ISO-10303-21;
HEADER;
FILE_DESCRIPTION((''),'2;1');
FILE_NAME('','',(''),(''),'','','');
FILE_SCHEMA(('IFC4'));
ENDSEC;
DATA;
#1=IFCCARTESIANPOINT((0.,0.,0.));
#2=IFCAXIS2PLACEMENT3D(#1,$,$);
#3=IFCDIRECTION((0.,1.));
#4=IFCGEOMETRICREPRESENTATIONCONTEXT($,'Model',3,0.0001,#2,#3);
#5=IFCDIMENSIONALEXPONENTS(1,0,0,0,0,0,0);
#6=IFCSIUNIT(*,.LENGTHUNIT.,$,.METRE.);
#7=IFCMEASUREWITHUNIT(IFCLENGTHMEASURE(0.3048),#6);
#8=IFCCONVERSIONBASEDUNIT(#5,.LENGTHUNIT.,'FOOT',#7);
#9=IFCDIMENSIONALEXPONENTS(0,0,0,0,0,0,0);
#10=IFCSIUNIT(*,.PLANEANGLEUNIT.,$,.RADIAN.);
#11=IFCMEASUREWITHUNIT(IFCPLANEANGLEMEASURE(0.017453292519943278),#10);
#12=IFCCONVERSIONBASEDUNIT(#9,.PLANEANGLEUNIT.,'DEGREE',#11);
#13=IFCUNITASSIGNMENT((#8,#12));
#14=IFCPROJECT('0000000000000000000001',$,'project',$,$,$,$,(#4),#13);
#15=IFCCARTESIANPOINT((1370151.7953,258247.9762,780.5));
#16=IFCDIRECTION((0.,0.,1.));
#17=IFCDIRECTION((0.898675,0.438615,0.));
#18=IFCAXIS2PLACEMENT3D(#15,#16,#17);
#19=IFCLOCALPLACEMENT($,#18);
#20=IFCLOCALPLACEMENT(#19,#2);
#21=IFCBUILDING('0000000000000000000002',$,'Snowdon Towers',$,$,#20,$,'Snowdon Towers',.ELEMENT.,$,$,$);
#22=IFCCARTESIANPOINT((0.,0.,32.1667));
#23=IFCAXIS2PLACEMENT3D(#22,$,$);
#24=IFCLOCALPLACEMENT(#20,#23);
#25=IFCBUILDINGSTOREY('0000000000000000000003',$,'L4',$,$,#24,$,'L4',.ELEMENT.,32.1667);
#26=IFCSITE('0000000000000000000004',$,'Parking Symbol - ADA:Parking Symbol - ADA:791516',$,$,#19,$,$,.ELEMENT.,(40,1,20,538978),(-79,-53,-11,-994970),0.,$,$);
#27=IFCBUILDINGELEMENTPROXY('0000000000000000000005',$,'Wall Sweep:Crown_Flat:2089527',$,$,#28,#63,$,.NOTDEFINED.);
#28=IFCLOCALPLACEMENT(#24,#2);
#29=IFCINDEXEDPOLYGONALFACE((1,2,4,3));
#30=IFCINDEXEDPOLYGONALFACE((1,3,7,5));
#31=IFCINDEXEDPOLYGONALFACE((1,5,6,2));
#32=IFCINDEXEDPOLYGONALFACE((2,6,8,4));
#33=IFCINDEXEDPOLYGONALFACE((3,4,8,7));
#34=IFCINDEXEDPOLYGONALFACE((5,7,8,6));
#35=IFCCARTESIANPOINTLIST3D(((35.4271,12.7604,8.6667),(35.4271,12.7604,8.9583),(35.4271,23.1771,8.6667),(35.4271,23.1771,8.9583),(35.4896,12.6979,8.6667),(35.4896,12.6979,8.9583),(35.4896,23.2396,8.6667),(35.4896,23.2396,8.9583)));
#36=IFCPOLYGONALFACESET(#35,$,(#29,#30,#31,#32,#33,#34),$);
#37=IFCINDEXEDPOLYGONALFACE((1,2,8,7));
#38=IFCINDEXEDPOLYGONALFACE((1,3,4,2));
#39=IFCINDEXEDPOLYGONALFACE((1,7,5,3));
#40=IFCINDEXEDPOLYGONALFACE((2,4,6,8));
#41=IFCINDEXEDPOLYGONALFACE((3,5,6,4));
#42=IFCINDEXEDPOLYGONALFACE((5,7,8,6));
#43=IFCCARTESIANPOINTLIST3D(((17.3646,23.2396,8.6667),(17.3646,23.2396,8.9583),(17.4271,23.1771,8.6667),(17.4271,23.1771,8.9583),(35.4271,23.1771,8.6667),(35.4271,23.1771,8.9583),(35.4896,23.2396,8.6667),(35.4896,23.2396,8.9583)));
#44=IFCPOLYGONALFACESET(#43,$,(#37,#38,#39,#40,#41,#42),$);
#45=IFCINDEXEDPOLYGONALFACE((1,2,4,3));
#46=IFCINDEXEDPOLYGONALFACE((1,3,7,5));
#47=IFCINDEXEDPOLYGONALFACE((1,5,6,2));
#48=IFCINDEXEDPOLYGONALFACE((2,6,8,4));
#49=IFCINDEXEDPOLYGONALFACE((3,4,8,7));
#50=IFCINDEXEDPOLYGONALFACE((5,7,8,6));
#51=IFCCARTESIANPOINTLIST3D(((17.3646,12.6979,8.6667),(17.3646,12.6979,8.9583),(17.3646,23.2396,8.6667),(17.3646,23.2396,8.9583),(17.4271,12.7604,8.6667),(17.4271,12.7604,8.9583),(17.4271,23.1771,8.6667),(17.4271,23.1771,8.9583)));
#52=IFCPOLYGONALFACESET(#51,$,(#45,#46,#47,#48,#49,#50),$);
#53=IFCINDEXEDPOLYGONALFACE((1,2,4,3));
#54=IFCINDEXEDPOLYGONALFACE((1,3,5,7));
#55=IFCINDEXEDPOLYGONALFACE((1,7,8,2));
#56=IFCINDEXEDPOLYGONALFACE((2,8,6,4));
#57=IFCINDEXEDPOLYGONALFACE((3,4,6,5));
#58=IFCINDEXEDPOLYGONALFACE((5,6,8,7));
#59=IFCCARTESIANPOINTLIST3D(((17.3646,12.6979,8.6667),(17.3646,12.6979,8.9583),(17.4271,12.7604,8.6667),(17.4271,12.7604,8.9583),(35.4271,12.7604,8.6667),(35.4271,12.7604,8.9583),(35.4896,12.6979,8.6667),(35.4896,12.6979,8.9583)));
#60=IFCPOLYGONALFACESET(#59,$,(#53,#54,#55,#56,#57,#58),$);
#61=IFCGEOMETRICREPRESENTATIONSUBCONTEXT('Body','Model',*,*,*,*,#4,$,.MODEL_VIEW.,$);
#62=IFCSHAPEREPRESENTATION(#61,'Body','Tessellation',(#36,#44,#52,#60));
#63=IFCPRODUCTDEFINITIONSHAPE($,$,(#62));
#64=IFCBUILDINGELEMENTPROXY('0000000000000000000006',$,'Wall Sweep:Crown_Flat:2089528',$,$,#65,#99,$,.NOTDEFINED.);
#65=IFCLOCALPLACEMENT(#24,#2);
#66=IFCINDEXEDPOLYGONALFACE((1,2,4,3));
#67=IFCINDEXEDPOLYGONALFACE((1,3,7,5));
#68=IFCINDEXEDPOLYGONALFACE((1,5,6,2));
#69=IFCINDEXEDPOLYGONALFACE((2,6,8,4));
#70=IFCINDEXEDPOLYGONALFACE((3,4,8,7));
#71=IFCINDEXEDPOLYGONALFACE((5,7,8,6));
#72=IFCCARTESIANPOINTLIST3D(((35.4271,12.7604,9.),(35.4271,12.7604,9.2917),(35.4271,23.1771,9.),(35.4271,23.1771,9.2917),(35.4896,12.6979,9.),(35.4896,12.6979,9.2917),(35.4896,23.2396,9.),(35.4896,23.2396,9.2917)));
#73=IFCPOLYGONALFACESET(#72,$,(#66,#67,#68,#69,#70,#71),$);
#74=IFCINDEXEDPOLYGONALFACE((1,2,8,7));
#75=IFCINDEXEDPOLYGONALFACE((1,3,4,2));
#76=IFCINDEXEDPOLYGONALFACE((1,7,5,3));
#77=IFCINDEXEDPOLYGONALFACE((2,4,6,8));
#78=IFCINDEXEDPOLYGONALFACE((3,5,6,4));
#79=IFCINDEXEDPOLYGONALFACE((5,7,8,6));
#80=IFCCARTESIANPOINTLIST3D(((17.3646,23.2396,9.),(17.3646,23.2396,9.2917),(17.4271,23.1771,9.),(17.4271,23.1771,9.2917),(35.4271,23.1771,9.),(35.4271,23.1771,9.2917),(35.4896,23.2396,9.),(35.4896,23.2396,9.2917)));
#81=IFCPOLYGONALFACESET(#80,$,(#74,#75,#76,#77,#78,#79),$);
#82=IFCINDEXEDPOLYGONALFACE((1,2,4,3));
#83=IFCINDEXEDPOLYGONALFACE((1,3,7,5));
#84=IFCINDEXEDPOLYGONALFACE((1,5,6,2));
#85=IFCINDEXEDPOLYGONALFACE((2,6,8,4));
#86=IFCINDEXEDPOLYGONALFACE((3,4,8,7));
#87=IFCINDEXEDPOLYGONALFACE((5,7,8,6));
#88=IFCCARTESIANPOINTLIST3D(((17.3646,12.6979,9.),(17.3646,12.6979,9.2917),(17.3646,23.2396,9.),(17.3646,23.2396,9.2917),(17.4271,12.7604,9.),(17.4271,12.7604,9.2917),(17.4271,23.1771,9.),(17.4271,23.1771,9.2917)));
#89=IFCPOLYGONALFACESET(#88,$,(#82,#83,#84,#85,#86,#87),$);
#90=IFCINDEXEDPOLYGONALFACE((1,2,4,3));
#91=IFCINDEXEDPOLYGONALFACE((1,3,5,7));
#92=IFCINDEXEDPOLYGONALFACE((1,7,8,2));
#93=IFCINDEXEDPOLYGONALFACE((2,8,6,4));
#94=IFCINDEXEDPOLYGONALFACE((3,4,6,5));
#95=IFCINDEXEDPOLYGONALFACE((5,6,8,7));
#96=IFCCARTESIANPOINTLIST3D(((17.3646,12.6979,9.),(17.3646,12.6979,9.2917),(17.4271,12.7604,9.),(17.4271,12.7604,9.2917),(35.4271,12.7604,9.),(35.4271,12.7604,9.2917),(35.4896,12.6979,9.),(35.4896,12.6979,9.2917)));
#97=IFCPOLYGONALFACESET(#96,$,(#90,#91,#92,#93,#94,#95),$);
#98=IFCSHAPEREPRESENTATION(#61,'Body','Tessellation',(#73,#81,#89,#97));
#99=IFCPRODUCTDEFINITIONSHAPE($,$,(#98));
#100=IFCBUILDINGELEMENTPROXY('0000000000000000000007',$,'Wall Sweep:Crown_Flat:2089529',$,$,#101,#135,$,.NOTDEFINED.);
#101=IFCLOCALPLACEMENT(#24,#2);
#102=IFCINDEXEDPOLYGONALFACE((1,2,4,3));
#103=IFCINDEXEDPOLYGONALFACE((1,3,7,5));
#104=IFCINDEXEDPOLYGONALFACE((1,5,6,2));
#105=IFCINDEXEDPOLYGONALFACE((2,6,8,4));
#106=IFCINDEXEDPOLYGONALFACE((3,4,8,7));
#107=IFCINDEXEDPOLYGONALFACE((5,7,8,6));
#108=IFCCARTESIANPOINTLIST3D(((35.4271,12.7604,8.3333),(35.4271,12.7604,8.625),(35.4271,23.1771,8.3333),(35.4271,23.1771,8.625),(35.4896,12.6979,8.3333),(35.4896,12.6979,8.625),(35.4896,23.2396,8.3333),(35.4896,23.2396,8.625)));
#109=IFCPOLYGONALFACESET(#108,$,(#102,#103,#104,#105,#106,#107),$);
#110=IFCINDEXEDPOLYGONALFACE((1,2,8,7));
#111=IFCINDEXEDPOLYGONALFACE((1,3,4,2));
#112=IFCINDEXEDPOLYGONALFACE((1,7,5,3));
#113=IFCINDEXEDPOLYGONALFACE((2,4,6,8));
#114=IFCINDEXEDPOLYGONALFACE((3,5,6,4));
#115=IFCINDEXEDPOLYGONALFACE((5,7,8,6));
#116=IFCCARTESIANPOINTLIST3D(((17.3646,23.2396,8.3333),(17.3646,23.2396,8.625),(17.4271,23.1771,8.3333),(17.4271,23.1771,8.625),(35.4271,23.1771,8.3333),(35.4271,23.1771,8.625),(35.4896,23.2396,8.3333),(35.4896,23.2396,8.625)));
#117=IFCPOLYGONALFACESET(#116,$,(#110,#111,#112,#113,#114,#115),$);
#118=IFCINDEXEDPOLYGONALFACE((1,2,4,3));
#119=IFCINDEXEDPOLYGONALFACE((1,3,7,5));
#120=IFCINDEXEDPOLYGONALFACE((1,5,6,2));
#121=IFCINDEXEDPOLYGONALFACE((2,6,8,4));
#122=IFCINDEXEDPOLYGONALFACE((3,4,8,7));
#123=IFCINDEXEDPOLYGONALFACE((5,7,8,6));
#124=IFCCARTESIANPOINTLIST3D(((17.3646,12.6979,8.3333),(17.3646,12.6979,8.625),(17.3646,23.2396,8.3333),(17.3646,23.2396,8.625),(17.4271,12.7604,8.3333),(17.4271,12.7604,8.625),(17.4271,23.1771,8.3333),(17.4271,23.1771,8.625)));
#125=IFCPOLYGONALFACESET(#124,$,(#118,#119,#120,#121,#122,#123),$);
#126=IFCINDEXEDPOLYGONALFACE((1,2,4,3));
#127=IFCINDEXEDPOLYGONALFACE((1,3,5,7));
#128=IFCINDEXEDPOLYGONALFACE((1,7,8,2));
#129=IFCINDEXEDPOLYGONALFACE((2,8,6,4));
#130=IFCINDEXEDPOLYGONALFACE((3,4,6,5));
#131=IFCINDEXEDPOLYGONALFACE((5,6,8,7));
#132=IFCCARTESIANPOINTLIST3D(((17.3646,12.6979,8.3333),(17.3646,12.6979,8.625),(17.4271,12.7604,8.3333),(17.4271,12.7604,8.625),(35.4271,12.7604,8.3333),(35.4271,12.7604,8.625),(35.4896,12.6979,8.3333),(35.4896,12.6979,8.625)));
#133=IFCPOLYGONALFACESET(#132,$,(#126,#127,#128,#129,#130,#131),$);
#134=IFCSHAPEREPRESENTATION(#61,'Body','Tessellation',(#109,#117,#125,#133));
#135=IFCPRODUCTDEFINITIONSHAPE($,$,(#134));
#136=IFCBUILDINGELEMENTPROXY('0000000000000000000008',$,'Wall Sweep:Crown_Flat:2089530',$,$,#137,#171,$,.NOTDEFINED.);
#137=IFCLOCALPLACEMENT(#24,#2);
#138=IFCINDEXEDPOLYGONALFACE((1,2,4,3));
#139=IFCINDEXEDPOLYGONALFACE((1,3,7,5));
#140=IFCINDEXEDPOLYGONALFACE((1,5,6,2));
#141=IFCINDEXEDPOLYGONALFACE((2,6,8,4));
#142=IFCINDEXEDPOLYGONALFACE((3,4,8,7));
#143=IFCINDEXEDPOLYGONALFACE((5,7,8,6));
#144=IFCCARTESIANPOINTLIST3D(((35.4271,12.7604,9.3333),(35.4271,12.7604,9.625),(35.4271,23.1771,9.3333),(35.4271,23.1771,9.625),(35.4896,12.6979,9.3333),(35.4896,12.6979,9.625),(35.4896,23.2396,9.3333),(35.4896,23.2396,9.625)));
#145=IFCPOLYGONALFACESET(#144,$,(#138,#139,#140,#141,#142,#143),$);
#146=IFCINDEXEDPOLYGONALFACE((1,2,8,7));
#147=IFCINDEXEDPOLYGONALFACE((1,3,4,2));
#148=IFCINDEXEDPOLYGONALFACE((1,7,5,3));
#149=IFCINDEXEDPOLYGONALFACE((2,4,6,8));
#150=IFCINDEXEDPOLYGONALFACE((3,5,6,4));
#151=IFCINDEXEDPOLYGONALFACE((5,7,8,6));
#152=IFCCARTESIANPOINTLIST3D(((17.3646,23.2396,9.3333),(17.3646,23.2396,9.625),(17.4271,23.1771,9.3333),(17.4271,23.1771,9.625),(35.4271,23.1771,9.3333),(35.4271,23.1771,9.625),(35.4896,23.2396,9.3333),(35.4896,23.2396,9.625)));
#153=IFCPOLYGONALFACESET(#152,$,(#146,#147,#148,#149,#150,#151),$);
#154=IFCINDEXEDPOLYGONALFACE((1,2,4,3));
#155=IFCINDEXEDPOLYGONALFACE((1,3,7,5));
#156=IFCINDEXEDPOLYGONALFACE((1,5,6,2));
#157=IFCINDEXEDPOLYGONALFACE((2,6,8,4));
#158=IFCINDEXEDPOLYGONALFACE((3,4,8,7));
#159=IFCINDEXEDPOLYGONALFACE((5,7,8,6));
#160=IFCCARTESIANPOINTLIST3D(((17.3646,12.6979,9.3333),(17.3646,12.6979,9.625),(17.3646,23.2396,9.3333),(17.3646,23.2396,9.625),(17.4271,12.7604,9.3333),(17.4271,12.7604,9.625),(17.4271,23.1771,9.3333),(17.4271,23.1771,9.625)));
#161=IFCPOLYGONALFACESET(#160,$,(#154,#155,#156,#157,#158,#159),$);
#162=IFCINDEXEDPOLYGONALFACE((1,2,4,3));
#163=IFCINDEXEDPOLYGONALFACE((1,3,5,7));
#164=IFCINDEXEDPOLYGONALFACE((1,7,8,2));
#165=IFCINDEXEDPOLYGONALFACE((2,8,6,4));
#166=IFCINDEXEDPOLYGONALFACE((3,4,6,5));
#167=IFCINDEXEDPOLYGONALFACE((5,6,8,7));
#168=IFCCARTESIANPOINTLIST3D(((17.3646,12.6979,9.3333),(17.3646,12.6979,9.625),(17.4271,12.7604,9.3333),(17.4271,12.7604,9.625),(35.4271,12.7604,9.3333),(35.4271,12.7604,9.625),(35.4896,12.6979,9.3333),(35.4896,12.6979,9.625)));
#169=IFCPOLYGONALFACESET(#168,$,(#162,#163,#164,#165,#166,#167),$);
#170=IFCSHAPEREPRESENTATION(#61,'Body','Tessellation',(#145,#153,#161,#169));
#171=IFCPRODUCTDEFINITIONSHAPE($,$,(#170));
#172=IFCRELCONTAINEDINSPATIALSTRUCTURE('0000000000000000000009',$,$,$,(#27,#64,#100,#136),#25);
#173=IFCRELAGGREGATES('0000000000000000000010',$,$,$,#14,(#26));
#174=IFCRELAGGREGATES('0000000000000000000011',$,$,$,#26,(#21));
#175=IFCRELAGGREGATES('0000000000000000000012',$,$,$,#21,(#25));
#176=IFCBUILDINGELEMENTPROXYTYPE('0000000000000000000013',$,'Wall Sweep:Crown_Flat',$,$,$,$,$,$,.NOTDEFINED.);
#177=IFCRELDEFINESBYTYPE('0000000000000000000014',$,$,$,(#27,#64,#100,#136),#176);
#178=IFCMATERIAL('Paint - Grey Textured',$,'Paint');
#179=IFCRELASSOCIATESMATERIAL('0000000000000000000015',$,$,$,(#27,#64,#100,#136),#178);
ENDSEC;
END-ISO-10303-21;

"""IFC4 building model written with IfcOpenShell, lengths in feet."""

from ifc_helpers import new_model, entity, si_unit, converted_unit, direction, frame, origin, place, context, subcontext, project, spatial, indexed_curve, outline, extrude, material, type_object, element, save


model = new_model("IFC4")

# Units and contexts
model_context = context("Model", 3, precision=0.0001, world=origin(), true_north=direction((0.0, 1.0)))
body_context = subcontext(model_context, "Body", "Model", "MODEL_VIEW")
ifc_project = project(units=[converted_unit("LENGTHUNIT", "FOOT", entity("IfcLengthMeasure", 0.3048), si_unit("LENGTHUNIT", "METRE"), dimensions=[1, 0, 0, 0, 0, 0, 0]), converted_unit("PLANEANGLEUNIT", "DEGREE", entity("IfcPlaneAngleMeasure", 0.017453292519943278), si_unit("PLANEANGLEUNIT", "RADIAN"), dimensions=[0, 0, 0, 0, 0, 0, 0])], contexts=[model_context])

# Site, building, storey
site_placement = place(None, frame((1370151.7953, 258247.9762, 780.5), z_axis=(0.0, 0.0, 1.0), x_axis=(0.898675, 0.438615, 0.0)))
site = spatial("IfcSite", under=ifc_project, at=site_placement, Name="Parking Symbol - ADA:Parking Symbol - ADA:791516", CompositionType="ELEMENT", RefLatitude=(40, 1, 20, 538978), RefLongitude=(-79, -53, -11, -994970), RefElevation=0.0)
building_placement = place(site_placement, origin())
building = spatial("IfcBuilding", under=site, at=building_placement, Name="Snowdon Towers", LongName="Snowdon Towers", CompositionType="ELEMENT")
storey_placement = place(building_placement, frame((0.0, 0.0, 32.1667)))
storey = spatial("IfcBuildingStorey", under=building, at=storey_placement, Name="L4", LongName="L4", CompositionType="ELEMENT", Elevation=32.1667)

# Building element proxies
ifc_material_1 = material(Name="Paint - Grey Textured", Category="Paint")
building_element_proxy_type_1 = type_object("IfcBuildingElementProxyType", Name="Wall Sweep:Crown_Flat", PredefinedType="NOTDEFINED")
proxy_1_placement = place(storey_placement, origin())
element("IfcBuildingElementProxy", 1, at=proxy_1_placement, inside=storey, type_object=building_element_proxy_type_1, material=ifc_material_1, Name="Wall Sweep:Crown_Flat:2089527", PredefinedType="NOTDEFINED", context=body_context, shape_type="SweptSolid", body=[
    extrude(outline(indexed_curve([(-5.2083, -0.0312), (5.2083, -0.0312), (5.2708, 0.0312), (-5.2708, 0.0312), (-5.2083, -0.0312)], self_intersect=False)), frame((35.4583, 17.9687, 8.6667), z_axis=(0.0, 0.0, 1.0), x_axis=(0.0, -1.0, 0.0)), (0.0, 0.0, 1.0), 0.2917),
    extrude(outline(indexed_curve([(-9.0, -0.0313), (9.0, -0.0313), (9.0625, 0.0312), (-9.0625, 0.0312), (-9.0, -0.0313)], self_intersect=False)), frame((26.4271, 23.2083, 8.6667)), (0.0, 0.0, 1.0), 0.2917),
    extrude(outline(indexed_curve([(-5.2083, -0.0313), (5.2083, -0.0312), (5.2708, 0.0313), (-5.2708, 0.0312), (-5.2083, -0.0313)], self_intersect=False)), frame((17.3958, 17.9687, 8.6667), z_axis=(0.0, 0.0, 1.0), x_axis=(0.0, 1.0, 0.0)), (0.0, 0.0, 1.0), 0.2917),
    extrude(outline(indexed_curve([(-9.0, -0.0312), (9.0, -0.0312), (9.0625, 0.0312), (-9.0625, 0.0313), (-9.0, -0.0312)], self_intersect=False)), frame((26.4271, 12.7292, 8.6667), z_axis=(0.0, 0.0, 1.0), x_axis=(-1.0, 0.0, 0.0)), (0.0, 0.0, 1.0), 0.2917),
])
proxy_2_placement = place(storey_placement, origin())
element("IfcBuildingElementProxy", 2, at=proxy_2_placement, inside=storey, type_object=building_element_proxy_type_1, material=ifc_material_1, Name="Wall Sweep:Crown_Flat:2089528", PredefinedType="NOTDEFINED", context=body_context, shape_type="SweptSolid", body=[
    extrude(outline(indexed_curve([(-5.2083, -0.0312), (5.2083, -0.0312), (5.2708, 0.0312), (-5.2708, 0.0312), (-5.2083, -0.0312)], self_intersect=False)), frame((35.4583, 17.9687, 9.0), z_axis=(0.0, 0.0, 1.0), x_axis=(0.0, -1.0, 0.0)), (0.0, 0.0, 1.0), 0.2917),
    extrude(outline(indexed_curve([(-9.0, -0.0313), (9.0, -0.0313), (9.0625, 0.0312), (-9.0625, 0.0312), (-9.0, -0.0313)], self_intersect=False)), frame((26.4271, 23.2083, 9.0)), (0.0, 0.0, 1.0), 0.2917),
    extrude(outline(indexed_curve([(-5.2083, -0.0313), (5.2083, -0.0312), (5.2708, 0.0313), (-5.2708, 0.0312), (-5.2083, -0.0313)], self_intersect=False)), frame((17.3958, 17.9687, 9.0), z_axis=(0.0, 0.0, 1.0), x_axis=(0.0, 1.0, 0.0)), (0.0, 0.0, 1.0), 0.2917),
    extrude(outline(indexed_curve([(-9.0, -0.0312), (9.0, -0.0312), (9.0625, 0.0312), (-9.0625, 0.0313), (-9.0, -0.0312)], self_intersect=False)), frame((26.4271, 12.7292, 9.0), z_axis=(0.0, 0.0, 1.0), x_axis=(-1.0, 0.0, 0.0)), (0.0, 0.0, 1.0), 0.2917),
])
proxy_3_placement = place(storey_placement, origin())
element("IfcBuildingElementProxy", 3, at=proxy_3_placement, inside=storey, type_object=building_element_proxy_type_1, material=ifc_material_1, Name="Wall Sweep:Crown_Flat:2089529", PredefinedType="NOTDEFINED", context=body_context, shape_type="SweptSolid", body=[
    extrude(outline(indexed_curve([(-5.2083, -0.0312), (5.2083, -0.0312), (5.2708, 0.0312), (-5.2708, 0.0312), (-5.2083, -0.0312)], self_intersect=False)), frame((35.4583, 17.9687, 8.3333), z_axis=(0.0, 0.0, 1.0), x_axis=(0.0, -1.0, 0.0)), (0.0, 0.0, 1.0), 0.2917),
    extrude(outline(indexed_curve([(-9.0, -0.0313), (9.0, -0.0313), (9.0625, 0.0312), (-9.0625, 0.0312), (-9.0, -0.0313)], self_intersect=False)), frame((26.4271, 23.2083, 8.3333)), (0.0, 0.0, 1.0), 0.2917),
    extrude(outline(indexed_curve([(-5.2083, -0.0313), (5.2083, -0.0312), (5.2708, 0.0313), (-5.2708, 0.0312), (-5.2083, -0.0313)], self_intersect=False)), frame((17.3958, 17.9687, 8.3333), z_axis=(0.0, 0.0, 1.0), x_axis=(0.0, 1.0, 0.0)), (0.0, 0.0, 1.0), 0.2917),
    extrude(outline(indexed_curve([(-9.0, -0.0312), (9.0, -0.0312), (9.0625, 0.0312), (-9.0625, 0.0313), (-9.0, -0.0312)], self_intersect=False)), frame((26.4271, 12.7292, 8.3333), z_axis=(0.0, 0.0, 1.0), x_axis=(-1.0, 0.0, 0.0)), (0.0, 0.0, 1.0), 0.2917),
])
proxy_4_placement = place(storey_placement, origin())
element("IfcBuildingElementProxy", 4, at=proxy_4_placement, inside=storey, type_object=building_element_proxy_type_1, material=ifc_material_1, Name="Wall Sweep:Crown_Flat:2089530", PredefinedType="NOTDEFINED", context=body_context, shape_type="SweptSolid", body=[
    extrude(outline(indexed_curve([(-5.2083, -0.0312), (5.2083, -0.0312), (5.2708, 0.0312), (-5.2708, 0.0312), (-5.2083, -0.0312)], self_intersect=False)), frame((35.4583, 17.9687, 9.3333), z_axis=(0.0, 0.0, 1.0), x_axis=(0.0, -1.0, 0.0)), (0.0, 0.0, 1.0), 0.2917),
    extrude(outline(indexed_curve([(-9.0, -0.0313), (9.0, -0.0313), (9.0625, 0.0312), (-9.0625, 0.0312), (-9.0, -0.0313)], self_intersect=False)), frame((26.4271, 23.2083, 9.3333)), (0.0, 0.0, 1.0), 0.2917),
    extrude(outline(indexed_curve([(-5.2083, -0.0313), (5.2083, -0.0312), (5.2708, 0.0313), (-5.2708, 0.0312), (-5.2083, -0.0313)], self_intersect=False)), frame((17.3958, 17.9687, 9.3333), z_axis=(0.0, 0.0, 1.0), x_axis=(0.0, 1.0, 0.0)), (0.0, 0.0, 1.0), 0.2917),
    extrude(outline(indexed_curve([(-9.0, -0.0312), (9.0, -0.0312), (9.0625, 0.0312), (-9.0625, 0.0313), (-9.0, -0.0312)], self_intersect=False)), frame((26.4271, 12.7292, 9.3333), z_axis=(0.0, 0.0, 1.0), x_axis=(-1.0, 0.0, 0.0)), (0.0, 0.0, 1.0), 0.2917),
])

save(model, "model.ifc")
